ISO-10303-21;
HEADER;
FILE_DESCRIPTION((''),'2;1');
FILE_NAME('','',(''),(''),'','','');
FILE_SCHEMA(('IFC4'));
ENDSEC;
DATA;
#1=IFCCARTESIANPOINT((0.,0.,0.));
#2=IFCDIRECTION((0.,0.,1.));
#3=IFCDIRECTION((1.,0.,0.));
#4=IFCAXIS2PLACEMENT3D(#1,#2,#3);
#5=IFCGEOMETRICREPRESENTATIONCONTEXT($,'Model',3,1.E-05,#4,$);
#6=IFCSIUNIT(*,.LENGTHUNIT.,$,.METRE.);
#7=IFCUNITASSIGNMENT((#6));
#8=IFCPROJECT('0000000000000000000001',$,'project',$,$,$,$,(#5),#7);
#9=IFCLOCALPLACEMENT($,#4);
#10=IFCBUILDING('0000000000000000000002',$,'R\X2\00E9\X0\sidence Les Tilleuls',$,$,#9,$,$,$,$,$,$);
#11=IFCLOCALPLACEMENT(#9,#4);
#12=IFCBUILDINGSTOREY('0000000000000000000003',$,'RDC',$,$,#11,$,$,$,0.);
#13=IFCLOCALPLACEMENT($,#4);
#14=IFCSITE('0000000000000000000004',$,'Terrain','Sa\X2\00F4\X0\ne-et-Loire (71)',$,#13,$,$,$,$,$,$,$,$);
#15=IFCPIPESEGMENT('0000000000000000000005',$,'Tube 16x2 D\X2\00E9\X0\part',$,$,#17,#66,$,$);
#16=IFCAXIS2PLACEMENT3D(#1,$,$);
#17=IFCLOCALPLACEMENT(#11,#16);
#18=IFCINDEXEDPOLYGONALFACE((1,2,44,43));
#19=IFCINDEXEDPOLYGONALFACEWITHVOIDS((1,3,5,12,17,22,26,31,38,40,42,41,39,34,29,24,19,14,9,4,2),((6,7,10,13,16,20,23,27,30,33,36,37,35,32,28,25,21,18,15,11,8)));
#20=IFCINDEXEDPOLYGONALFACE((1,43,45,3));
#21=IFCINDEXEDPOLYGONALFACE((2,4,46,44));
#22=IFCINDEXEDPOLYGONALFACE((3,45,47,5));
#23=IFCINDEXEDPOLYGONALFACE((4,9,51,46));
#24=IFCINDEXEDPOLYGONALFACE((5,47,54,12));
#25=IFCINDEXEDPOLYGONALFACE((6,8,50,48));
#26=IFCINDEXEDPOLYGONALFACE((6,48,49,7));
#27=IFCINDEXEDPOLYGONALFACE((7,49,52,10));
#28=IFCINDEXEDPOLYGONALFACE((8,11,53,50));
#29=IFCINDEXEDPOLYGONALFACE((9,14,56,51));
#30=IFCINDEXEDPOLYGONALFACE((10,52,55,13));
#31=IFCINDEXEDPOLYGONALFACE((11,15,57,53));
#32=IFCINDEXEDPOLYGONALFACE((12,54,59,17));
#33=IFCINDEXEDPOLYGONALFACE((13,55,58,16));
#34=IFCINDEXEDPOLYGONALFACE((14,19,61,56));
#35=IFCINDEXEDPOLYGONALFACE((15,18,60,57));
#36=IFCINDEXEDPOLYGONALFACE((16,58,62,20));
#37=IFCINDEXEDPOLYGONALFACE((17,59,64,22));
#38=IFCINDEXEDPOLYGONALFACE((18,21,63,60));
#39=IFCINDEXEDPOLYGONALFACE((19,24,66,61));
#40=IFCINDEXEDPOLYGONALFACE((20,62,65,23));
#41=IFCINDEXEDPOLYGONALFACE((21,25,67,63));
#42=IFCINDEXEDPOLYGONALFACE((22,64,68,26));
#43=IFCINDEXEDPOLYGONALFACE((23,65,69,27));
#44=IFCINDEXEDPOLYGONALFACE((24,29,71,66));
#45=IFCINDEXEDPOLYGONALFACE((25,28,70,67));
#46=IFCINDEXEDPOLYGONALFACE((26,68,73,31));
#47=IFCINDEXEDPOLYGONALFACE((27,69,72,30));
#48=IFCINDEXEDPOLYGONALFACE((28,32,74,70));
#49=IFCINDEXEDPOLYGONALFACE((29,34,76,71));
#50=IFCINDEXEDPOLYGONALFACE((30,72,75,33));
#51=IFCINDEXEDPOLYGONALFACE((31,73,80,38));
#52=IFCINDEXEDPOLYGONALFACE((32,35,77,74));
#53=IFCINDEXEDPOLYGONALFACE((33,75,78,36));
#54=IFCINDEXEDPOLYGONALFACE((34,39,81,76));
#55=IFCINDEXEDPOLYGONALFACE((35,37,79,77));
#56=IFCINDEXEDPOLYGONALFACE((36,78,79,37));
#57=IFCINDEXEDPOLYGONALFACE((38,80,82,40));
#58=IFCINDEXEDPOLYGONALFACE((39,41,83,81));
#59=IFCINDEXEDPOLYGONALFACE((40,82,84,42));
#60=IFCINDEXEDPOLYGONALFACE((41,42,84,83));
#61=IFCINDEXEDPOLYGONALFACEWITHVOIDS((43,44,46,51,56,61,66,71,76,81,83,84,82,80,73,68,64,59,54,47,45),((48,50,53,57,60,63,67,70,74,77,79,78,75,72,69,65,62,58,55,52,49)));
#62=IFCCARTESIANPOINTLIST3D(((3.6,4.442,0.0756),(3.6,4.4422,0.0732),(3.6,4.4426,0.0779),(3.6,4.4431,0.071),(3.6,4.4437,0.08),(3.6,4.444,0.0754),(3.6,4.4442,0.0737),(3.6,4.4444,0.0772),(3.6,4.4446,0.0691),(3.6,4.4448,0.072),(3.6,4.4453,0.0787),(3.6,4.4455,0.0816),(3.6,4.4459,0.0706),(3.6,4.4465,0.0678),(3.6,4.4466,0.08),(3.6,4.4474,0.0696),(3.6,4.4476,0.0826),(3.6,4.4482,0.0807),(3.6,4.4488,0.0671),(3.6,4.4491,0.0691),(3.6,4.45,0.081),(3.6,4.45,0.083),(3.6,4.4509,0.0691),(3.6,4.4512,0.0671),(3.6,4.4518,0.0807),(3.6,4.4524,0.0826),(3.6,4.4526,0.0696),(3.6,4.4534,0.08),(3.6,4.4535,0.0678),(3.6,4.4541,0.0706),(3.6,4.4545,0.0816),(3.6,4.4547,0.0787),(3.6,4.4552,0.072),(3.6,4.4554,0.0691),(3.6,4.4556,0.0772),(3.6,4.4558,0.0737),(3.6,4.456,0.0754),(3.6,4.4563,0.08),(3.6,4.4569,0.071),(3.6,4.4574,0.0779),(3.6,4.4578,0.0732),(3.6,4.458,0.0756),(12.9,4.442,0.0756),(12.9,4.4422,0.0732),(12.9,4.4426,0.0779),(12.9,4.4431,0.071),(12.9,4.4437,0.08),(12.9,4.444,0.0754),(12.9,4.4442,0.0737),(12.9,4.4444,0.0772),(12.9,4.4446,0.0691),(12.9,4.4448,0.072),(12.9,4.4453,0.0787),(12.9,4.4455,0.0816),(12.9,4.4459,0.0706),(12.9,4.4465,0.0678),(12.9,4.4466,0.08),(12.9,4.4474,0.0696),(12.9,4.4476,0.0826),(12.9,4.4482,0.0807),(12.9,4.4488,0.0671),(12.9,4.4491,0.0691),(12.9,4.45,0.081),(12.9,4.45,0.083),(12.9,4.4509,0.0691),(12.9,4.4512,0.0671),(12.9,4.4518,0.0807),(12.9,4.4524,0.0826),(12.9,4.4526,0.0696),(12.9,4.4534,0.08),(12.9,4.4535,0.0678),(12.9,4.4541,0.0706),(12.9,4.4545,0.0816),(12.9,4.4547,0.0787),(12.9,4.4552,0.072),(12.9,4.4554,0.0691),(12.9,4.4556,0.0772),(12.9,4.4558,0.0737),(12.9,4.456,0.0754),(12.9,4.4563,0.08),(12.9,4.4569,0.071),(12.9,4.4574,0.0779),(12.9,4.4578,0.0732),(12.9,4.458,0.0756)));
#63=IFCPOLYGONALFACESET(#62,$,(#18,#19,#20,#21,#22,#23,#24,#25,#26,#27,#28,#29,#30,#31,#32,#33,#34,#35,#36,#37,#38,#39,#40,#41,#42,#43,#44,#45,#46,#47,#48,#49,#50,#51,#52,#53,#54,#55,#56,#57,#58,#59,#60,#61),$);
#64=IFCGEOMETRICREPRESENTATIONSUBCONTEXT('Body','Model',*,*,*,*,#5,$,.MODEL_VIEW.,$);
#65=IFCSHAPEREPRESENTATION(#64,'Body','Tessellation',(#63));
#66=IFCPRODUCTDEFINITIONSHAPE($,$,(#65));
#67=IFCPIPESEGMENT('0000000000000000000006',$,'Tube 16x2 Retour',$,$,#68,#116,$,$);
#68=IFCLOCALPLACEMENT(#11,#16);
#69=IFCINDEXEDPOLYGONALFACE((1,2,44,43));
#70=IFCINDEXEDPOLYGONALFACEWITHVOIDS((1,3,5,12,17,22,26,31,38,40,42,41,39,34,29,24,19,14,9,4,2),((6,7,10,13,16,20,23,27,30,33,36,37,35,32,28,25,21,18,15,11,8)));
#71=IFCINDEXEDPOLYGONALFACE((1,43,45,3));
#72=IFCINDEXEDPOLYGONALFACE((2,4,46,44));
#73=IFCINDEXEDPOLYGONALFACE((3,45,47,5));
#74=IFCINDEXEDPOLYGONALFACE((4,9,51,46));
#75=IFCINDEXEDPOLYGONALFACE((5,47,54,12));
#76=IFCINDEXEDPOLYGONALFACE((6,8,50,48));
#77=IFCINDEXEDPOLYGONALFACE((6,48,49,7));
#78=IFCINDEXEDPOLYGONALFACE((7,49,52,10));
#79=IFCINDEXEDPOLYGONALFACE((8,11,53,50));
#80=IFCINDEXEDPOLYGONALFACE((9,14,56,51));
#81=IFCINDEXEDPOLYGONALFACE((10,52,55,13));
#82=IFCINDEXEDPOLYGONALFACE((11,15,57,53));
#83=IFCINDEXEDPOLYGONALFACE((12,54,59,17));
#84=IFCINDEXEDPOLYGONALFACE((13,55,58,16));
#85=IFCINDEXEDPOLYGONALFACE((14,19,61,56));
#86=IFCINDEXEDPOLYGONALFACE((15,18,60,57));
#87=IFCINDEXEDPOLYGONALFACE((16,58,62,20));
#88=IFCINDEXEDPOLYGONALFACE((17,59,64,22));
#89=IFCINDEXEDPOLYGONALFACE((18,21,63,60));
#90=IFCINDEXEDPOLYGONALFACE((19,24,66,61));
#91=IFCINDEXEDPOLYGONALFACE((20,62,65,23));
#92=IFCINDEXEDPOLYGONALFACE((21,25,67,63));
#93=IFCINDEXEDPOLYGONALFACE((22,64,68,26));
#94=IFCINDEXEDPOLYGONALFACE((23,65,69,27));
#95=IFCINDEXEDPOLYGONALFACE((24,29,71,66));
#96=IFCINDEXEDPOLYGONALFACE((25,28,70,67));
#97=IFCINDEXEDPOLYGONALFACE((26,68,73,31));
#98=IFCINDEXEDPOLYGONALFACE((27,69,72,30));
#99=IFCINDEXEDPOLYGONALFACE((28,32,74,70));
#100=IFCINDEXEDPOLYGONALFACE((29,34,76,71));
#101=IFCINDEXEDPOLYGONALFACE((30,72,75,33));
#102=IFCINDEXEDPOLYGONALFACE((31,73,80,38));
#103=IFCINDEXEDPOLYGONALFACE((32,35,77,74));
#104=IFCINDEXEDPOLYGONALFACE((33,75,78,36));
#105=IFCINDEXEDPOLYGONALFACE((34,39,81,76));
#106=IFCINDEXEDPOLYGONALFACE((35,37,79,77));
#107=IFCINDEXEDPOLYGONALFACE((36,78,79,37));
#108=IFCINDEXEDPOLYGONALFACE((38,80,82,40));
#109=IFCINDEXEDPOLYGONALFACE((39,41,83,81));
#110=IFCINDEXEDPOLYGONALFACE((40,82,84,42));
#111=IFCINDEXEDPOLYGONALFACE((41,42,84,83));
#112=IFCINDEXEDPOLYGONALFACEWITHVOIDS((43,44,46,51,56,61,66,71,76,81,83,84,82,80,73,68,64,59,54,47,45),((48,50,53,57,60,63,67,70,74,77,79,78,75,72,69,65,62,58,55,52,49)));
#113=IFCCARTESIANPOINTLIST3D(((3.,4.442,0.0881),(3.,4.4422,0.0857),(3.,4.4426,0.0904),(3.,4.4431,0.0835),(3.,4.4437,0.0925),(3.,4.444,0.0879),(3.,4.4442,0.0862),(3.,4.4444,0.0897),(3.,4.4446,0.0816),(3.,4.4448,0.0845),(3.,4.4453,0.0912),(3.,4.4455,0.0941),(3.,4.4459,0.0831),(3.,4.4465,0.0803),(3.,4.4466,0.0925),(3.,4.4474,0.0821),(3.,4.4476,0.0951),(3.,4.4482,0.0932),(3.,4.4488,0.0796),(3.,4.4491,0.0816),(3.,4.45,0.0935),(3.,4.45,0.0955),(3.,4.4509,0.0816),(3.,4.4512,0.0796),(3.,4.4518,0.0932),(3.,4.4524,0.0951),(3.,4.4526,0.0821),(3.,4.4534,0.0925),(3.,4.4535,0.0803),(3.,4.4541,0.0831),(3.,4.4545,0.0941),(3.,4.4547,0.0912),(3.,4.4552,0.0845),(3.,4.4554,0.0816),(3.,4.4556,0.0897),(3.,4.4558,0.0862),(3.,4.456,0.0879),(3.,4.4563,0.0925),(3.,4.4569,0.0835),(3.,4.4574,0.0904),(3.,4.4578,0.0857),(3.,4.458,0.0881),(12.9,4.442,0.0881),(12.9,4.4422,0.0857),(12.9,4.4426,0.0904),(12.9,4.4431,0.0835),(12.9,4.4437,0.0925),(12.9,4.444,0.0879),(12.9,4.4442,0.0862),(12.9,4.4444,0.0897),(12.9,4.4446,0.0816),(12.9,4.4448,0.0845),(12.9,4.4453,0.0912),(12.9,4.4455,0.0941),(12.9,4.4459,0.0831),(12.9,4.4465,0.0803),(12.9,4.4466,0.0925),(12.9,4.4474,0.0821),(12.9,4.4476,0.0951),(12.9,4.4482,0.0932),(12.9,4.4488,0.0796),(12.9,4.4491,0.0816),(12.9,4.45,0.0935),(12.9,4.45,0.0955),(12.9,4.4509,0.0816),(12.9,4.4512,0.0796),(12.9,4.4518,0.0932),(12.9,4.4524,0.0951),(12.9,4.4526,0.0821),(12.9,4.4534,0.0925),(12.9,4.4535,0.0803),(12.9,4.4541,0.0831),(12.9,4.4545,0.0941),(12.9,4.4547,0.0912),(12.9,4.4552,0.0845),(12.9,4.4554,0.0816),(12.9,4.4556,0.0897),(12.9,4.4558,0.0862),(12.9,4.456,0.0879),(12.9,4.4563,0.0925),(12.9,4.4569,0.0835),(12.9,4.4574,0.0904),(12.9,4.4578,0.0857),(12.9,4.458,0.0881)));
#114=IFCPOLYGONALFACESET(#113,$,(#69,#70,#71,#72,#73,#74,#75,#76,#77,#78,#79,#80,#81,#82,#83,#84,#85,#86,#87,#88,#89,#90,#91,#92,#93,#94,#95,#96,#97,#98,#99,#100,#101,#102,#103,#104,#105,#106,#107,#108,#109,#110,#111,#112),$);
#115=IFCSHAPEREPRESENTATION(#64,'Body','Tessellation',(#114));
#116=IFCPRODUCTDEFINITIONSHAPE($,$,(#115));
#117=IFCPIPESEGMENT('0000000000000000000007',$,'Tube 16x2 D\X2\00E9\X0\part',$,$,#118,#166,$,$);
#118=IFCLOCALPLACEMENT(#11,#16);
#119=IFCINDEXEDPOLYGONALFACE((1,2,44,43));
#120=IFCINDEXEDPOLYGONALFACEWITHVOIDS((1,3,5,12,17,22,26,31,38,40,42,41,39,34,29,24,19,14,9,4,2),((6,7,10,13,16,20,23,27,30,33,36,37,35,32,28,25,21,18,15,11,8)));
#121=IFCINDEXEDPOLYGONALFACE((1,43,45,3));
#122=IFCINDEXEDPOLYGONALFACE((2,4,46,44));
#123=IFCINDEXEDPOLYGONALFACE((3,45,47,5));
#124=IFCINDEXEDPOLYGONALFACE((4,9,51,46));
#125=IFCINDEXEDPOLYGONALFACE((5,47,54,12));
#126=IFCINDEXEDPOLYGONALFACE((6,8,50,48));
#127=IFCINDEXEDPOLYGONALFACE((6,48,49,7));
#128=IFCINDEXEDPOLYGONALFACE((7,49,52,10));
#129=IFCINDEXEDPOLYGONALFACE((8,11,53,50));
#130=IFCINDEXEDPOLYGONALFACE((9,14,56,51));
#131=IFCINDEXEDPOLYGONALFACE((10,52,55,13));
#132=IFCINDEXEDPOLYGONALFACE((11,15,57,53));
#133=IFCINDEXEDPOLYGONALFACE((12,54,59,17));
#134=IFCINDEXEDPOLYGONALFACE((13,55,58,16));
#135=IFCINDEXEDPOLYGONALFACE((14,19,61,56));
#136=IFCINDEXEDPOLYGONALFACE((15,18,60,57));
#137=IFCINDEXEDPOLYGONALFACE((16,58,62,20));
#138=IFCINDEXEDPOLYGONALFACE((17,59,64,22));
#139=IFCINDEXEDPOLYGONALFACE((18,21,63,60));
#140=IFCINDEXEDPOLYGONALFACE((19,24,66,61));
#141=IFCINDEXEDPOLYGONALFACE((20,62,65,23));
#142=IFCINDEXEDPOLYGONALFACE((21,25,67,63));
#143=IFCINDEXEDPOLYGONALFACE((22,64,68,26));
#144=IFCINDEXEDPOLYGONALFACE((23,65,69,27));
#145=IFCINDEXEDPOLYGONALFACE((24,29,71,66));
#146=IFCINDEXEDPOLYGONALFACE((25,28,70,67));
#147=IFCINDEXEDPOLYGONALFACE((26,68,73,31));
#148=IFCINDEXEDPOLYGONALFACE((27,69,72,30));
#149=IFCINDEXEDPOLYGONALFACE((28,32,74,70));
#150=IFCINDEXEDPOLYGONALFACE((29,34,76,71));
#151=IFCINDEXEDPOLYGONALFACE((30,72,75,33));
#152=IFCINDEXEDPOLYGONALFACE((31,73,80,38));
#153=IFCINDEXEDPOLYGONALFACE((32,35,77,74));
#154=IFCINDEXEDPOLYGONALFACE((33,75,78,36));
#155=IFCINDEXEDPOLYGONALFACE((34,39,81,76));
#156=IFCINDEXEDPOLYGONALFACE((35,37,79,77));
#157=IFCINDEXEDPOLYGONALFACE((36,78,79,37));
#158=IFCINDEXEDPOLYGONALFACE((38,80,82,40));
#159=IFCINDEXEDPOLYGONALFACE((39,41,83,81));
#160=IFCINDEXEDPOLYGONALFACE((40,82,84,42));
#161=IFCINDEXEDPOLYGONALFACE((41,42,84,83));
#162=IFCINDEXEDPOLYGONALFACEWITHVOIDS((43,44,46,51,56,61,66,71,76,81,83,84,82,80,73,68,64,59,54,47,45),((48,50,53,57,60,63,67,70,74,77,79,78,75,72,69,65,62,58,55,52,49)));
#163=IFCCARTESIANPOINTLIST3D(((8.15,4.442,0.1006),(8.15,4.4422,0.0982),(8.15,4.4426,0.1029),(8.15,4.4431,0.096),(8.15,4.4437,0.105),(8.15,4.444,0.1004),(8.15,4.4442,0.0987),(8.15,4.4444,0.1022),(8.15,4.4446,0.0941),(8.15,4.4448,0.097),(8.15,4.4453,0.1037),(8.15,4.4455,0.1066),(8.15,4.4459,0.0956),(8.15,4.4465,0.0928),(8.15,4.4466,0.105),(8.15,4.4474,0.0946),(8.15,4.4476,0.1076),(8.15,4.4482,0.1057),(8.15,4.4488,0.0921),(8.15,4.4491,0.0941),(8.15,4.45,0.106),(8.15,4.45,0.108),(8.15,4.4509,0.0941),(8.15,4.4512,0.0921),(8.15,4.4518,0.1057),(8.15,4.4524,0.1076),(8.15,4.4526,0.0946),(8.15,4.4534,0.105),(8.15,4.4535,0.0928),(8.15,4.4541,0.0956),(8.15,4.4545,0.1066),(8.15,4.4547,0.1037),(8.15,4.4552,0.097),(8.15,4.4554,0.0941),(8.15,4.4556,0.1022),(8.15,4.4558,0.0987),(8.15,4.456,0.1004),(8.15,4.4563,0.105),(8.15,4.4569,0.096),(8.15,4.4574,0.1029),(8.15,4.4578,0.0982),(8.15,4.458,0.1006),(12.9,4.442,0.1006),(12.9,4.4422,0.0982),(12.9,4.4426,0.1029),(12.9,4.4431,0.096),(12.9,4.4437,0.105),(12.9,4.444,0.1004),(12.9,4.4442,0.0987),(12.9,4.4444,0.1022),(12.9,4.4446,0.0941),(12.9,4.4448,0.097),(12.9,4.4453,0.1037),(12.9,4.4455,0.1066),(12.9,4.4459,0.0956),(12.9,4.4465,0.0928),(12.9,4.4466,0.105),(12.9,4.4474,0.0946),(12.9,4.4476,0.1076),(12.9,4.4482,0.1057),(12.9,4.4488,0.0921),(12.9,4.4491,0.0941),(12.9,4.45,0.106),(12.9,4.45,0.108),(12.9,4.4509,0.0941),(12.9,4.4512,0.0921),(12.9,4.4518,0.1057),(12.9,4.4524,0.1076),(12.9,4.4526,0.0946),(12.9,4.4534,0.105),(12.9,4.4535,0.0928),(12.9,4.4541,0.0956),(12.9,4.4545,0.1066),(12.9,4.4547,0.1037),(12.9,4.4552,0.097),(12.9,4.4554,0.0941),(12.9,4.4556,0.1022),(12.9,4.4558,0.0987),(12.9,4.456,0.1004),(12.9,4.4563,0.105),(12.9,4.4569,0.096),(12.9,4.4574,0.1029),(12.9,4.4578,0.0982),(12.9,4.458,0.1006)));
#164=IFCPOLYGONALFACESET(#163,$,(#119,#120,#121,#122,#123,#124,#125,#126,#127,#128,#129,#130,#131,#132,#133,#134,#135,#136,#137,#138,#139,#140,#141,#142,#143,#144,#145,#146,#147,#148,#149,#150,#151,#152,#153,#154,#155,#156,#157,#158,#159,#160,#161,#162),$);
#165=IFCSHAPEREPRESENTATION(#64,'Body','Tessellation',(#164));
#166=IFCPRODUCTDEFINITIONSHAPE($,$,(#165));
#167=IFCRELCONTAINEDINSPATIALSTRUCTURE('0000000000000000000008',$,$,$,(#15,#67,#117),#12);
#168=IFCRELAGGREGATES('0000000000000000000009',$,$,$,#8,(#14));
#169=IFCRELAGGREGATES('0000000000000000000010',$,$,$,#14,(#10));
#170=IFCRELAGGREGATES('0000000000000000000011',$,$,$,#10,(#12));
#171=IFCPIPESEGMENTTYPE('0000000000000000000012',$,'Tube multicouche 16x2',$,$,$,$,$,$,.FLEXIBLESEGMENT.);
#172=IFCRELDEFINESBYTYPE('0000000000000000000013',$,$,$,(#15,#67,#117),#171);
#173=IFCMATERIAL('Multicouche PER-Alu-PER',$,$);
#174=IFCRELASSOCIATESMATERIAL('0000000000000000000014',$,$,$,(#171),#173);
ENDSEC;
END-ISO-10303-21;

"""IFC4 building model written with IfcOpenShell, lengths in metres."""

from ifc_helpers import new_model, si_unit, frame, origin_with_axes, place, context, subcontext, project, spatial, hollow_circle, extrude, material, type_object, element, save


model = new_model("IFC4")

# Units and contexts
model_context = context("Model", 3, precision=1e-05, world=origin_with_axes())
body_context = subcontext(model_context, "Body", "Model", "MODEL_VIEW")
ifc_project = project(units=[si_unit("LENGTHUNIT", "METRE")], contexts=[model_context])

# Site, building, storey
site_placement = place(None, origin_with_axes())
site = spatial("IfcSite", under=ifc_project, at=site_placement, Name="Terrain", Description="Saône-et-Loire (71)")
building_placement = place(None, origin_with_axes())
building = spatial("IfcBuilding", under=site, at=building_placement, Name="Résidence Les Tilleuls")
storey_placement = place(building_placement, origin_with_axes())
storey = spatial("IfcBuildingStorey", under=building, at=storey_placement, Name="RDC", Elevation=0.0)

# Pipe segments
ifc_material = material(Name="Multicouche PER-Alu-PER")
pipe_segment_type_1 = type_object("IfcPipeSegmentType", Name="Tube multicouche 16x2", PredefinedType="FLEXIBLESEGMENT", material=ifc_material)
pipe_segment_1_placement = place(storey_placement, frame((12.9, 4.45, 0.075), z_axis=(-1.0, 0.0, 0.0), x_axis=(0.0, 0.0, 1.0)))
element("IfcPipeSegment", 1, at=pipe_segment_1_placement, inside=storey, type_object=pipe_segment_type_1, Name="Tube 16x2 Départ", context=body_context, shape_type="SweptSolid", body=[
    extrude(hollow_circle(Radius=0.008, WallThickness=0.002), origin_with_axes(), (0.0, 0.0, 1.0), 9.3),
])
pipe_segment_2_placement = place(storey_placement, frame((12.9, 4.45, 0.0875), z_axis=(-1.0, 0.0, 0.0), x_axis=(0.0, 0.0, 1.0)))
element("IfcPipeSegment", 2, at=pipe_segment_2_placement, inside=storey, type_object=pipe_segment_type_1, Name="Tube 16x2 Retour", context=body_context, shape_type="SweptSolid", body=[
    extrude(hollow_circle(Radius=0.008, WallThickness=0.002), origin_with_axes(), (0.0, 0.0, 1.0), 9.9),
])
pipe_segment_3_placement = place(storey_placement, frame((12.9, 4.45, 0.1), z_axis=(-1.0, 0.0, 0.0), x_axis=(0.0, 0.0, 1.0)))
element("IfcPipeSegment", 3, at=pipe_segment_3_placement, inside=storey, type_object=pipe_segment_type_1, Name="Tube 16x2 Départ", context=body_context, shape_type="SweptSolid", body=[
    extrude(hollow_circle(Radius=0.008, WallThickness=0.002), origin_with_axes(), (0.0, 0.0, 1.0), 4.75),
])

save(model, "model.ifc")
